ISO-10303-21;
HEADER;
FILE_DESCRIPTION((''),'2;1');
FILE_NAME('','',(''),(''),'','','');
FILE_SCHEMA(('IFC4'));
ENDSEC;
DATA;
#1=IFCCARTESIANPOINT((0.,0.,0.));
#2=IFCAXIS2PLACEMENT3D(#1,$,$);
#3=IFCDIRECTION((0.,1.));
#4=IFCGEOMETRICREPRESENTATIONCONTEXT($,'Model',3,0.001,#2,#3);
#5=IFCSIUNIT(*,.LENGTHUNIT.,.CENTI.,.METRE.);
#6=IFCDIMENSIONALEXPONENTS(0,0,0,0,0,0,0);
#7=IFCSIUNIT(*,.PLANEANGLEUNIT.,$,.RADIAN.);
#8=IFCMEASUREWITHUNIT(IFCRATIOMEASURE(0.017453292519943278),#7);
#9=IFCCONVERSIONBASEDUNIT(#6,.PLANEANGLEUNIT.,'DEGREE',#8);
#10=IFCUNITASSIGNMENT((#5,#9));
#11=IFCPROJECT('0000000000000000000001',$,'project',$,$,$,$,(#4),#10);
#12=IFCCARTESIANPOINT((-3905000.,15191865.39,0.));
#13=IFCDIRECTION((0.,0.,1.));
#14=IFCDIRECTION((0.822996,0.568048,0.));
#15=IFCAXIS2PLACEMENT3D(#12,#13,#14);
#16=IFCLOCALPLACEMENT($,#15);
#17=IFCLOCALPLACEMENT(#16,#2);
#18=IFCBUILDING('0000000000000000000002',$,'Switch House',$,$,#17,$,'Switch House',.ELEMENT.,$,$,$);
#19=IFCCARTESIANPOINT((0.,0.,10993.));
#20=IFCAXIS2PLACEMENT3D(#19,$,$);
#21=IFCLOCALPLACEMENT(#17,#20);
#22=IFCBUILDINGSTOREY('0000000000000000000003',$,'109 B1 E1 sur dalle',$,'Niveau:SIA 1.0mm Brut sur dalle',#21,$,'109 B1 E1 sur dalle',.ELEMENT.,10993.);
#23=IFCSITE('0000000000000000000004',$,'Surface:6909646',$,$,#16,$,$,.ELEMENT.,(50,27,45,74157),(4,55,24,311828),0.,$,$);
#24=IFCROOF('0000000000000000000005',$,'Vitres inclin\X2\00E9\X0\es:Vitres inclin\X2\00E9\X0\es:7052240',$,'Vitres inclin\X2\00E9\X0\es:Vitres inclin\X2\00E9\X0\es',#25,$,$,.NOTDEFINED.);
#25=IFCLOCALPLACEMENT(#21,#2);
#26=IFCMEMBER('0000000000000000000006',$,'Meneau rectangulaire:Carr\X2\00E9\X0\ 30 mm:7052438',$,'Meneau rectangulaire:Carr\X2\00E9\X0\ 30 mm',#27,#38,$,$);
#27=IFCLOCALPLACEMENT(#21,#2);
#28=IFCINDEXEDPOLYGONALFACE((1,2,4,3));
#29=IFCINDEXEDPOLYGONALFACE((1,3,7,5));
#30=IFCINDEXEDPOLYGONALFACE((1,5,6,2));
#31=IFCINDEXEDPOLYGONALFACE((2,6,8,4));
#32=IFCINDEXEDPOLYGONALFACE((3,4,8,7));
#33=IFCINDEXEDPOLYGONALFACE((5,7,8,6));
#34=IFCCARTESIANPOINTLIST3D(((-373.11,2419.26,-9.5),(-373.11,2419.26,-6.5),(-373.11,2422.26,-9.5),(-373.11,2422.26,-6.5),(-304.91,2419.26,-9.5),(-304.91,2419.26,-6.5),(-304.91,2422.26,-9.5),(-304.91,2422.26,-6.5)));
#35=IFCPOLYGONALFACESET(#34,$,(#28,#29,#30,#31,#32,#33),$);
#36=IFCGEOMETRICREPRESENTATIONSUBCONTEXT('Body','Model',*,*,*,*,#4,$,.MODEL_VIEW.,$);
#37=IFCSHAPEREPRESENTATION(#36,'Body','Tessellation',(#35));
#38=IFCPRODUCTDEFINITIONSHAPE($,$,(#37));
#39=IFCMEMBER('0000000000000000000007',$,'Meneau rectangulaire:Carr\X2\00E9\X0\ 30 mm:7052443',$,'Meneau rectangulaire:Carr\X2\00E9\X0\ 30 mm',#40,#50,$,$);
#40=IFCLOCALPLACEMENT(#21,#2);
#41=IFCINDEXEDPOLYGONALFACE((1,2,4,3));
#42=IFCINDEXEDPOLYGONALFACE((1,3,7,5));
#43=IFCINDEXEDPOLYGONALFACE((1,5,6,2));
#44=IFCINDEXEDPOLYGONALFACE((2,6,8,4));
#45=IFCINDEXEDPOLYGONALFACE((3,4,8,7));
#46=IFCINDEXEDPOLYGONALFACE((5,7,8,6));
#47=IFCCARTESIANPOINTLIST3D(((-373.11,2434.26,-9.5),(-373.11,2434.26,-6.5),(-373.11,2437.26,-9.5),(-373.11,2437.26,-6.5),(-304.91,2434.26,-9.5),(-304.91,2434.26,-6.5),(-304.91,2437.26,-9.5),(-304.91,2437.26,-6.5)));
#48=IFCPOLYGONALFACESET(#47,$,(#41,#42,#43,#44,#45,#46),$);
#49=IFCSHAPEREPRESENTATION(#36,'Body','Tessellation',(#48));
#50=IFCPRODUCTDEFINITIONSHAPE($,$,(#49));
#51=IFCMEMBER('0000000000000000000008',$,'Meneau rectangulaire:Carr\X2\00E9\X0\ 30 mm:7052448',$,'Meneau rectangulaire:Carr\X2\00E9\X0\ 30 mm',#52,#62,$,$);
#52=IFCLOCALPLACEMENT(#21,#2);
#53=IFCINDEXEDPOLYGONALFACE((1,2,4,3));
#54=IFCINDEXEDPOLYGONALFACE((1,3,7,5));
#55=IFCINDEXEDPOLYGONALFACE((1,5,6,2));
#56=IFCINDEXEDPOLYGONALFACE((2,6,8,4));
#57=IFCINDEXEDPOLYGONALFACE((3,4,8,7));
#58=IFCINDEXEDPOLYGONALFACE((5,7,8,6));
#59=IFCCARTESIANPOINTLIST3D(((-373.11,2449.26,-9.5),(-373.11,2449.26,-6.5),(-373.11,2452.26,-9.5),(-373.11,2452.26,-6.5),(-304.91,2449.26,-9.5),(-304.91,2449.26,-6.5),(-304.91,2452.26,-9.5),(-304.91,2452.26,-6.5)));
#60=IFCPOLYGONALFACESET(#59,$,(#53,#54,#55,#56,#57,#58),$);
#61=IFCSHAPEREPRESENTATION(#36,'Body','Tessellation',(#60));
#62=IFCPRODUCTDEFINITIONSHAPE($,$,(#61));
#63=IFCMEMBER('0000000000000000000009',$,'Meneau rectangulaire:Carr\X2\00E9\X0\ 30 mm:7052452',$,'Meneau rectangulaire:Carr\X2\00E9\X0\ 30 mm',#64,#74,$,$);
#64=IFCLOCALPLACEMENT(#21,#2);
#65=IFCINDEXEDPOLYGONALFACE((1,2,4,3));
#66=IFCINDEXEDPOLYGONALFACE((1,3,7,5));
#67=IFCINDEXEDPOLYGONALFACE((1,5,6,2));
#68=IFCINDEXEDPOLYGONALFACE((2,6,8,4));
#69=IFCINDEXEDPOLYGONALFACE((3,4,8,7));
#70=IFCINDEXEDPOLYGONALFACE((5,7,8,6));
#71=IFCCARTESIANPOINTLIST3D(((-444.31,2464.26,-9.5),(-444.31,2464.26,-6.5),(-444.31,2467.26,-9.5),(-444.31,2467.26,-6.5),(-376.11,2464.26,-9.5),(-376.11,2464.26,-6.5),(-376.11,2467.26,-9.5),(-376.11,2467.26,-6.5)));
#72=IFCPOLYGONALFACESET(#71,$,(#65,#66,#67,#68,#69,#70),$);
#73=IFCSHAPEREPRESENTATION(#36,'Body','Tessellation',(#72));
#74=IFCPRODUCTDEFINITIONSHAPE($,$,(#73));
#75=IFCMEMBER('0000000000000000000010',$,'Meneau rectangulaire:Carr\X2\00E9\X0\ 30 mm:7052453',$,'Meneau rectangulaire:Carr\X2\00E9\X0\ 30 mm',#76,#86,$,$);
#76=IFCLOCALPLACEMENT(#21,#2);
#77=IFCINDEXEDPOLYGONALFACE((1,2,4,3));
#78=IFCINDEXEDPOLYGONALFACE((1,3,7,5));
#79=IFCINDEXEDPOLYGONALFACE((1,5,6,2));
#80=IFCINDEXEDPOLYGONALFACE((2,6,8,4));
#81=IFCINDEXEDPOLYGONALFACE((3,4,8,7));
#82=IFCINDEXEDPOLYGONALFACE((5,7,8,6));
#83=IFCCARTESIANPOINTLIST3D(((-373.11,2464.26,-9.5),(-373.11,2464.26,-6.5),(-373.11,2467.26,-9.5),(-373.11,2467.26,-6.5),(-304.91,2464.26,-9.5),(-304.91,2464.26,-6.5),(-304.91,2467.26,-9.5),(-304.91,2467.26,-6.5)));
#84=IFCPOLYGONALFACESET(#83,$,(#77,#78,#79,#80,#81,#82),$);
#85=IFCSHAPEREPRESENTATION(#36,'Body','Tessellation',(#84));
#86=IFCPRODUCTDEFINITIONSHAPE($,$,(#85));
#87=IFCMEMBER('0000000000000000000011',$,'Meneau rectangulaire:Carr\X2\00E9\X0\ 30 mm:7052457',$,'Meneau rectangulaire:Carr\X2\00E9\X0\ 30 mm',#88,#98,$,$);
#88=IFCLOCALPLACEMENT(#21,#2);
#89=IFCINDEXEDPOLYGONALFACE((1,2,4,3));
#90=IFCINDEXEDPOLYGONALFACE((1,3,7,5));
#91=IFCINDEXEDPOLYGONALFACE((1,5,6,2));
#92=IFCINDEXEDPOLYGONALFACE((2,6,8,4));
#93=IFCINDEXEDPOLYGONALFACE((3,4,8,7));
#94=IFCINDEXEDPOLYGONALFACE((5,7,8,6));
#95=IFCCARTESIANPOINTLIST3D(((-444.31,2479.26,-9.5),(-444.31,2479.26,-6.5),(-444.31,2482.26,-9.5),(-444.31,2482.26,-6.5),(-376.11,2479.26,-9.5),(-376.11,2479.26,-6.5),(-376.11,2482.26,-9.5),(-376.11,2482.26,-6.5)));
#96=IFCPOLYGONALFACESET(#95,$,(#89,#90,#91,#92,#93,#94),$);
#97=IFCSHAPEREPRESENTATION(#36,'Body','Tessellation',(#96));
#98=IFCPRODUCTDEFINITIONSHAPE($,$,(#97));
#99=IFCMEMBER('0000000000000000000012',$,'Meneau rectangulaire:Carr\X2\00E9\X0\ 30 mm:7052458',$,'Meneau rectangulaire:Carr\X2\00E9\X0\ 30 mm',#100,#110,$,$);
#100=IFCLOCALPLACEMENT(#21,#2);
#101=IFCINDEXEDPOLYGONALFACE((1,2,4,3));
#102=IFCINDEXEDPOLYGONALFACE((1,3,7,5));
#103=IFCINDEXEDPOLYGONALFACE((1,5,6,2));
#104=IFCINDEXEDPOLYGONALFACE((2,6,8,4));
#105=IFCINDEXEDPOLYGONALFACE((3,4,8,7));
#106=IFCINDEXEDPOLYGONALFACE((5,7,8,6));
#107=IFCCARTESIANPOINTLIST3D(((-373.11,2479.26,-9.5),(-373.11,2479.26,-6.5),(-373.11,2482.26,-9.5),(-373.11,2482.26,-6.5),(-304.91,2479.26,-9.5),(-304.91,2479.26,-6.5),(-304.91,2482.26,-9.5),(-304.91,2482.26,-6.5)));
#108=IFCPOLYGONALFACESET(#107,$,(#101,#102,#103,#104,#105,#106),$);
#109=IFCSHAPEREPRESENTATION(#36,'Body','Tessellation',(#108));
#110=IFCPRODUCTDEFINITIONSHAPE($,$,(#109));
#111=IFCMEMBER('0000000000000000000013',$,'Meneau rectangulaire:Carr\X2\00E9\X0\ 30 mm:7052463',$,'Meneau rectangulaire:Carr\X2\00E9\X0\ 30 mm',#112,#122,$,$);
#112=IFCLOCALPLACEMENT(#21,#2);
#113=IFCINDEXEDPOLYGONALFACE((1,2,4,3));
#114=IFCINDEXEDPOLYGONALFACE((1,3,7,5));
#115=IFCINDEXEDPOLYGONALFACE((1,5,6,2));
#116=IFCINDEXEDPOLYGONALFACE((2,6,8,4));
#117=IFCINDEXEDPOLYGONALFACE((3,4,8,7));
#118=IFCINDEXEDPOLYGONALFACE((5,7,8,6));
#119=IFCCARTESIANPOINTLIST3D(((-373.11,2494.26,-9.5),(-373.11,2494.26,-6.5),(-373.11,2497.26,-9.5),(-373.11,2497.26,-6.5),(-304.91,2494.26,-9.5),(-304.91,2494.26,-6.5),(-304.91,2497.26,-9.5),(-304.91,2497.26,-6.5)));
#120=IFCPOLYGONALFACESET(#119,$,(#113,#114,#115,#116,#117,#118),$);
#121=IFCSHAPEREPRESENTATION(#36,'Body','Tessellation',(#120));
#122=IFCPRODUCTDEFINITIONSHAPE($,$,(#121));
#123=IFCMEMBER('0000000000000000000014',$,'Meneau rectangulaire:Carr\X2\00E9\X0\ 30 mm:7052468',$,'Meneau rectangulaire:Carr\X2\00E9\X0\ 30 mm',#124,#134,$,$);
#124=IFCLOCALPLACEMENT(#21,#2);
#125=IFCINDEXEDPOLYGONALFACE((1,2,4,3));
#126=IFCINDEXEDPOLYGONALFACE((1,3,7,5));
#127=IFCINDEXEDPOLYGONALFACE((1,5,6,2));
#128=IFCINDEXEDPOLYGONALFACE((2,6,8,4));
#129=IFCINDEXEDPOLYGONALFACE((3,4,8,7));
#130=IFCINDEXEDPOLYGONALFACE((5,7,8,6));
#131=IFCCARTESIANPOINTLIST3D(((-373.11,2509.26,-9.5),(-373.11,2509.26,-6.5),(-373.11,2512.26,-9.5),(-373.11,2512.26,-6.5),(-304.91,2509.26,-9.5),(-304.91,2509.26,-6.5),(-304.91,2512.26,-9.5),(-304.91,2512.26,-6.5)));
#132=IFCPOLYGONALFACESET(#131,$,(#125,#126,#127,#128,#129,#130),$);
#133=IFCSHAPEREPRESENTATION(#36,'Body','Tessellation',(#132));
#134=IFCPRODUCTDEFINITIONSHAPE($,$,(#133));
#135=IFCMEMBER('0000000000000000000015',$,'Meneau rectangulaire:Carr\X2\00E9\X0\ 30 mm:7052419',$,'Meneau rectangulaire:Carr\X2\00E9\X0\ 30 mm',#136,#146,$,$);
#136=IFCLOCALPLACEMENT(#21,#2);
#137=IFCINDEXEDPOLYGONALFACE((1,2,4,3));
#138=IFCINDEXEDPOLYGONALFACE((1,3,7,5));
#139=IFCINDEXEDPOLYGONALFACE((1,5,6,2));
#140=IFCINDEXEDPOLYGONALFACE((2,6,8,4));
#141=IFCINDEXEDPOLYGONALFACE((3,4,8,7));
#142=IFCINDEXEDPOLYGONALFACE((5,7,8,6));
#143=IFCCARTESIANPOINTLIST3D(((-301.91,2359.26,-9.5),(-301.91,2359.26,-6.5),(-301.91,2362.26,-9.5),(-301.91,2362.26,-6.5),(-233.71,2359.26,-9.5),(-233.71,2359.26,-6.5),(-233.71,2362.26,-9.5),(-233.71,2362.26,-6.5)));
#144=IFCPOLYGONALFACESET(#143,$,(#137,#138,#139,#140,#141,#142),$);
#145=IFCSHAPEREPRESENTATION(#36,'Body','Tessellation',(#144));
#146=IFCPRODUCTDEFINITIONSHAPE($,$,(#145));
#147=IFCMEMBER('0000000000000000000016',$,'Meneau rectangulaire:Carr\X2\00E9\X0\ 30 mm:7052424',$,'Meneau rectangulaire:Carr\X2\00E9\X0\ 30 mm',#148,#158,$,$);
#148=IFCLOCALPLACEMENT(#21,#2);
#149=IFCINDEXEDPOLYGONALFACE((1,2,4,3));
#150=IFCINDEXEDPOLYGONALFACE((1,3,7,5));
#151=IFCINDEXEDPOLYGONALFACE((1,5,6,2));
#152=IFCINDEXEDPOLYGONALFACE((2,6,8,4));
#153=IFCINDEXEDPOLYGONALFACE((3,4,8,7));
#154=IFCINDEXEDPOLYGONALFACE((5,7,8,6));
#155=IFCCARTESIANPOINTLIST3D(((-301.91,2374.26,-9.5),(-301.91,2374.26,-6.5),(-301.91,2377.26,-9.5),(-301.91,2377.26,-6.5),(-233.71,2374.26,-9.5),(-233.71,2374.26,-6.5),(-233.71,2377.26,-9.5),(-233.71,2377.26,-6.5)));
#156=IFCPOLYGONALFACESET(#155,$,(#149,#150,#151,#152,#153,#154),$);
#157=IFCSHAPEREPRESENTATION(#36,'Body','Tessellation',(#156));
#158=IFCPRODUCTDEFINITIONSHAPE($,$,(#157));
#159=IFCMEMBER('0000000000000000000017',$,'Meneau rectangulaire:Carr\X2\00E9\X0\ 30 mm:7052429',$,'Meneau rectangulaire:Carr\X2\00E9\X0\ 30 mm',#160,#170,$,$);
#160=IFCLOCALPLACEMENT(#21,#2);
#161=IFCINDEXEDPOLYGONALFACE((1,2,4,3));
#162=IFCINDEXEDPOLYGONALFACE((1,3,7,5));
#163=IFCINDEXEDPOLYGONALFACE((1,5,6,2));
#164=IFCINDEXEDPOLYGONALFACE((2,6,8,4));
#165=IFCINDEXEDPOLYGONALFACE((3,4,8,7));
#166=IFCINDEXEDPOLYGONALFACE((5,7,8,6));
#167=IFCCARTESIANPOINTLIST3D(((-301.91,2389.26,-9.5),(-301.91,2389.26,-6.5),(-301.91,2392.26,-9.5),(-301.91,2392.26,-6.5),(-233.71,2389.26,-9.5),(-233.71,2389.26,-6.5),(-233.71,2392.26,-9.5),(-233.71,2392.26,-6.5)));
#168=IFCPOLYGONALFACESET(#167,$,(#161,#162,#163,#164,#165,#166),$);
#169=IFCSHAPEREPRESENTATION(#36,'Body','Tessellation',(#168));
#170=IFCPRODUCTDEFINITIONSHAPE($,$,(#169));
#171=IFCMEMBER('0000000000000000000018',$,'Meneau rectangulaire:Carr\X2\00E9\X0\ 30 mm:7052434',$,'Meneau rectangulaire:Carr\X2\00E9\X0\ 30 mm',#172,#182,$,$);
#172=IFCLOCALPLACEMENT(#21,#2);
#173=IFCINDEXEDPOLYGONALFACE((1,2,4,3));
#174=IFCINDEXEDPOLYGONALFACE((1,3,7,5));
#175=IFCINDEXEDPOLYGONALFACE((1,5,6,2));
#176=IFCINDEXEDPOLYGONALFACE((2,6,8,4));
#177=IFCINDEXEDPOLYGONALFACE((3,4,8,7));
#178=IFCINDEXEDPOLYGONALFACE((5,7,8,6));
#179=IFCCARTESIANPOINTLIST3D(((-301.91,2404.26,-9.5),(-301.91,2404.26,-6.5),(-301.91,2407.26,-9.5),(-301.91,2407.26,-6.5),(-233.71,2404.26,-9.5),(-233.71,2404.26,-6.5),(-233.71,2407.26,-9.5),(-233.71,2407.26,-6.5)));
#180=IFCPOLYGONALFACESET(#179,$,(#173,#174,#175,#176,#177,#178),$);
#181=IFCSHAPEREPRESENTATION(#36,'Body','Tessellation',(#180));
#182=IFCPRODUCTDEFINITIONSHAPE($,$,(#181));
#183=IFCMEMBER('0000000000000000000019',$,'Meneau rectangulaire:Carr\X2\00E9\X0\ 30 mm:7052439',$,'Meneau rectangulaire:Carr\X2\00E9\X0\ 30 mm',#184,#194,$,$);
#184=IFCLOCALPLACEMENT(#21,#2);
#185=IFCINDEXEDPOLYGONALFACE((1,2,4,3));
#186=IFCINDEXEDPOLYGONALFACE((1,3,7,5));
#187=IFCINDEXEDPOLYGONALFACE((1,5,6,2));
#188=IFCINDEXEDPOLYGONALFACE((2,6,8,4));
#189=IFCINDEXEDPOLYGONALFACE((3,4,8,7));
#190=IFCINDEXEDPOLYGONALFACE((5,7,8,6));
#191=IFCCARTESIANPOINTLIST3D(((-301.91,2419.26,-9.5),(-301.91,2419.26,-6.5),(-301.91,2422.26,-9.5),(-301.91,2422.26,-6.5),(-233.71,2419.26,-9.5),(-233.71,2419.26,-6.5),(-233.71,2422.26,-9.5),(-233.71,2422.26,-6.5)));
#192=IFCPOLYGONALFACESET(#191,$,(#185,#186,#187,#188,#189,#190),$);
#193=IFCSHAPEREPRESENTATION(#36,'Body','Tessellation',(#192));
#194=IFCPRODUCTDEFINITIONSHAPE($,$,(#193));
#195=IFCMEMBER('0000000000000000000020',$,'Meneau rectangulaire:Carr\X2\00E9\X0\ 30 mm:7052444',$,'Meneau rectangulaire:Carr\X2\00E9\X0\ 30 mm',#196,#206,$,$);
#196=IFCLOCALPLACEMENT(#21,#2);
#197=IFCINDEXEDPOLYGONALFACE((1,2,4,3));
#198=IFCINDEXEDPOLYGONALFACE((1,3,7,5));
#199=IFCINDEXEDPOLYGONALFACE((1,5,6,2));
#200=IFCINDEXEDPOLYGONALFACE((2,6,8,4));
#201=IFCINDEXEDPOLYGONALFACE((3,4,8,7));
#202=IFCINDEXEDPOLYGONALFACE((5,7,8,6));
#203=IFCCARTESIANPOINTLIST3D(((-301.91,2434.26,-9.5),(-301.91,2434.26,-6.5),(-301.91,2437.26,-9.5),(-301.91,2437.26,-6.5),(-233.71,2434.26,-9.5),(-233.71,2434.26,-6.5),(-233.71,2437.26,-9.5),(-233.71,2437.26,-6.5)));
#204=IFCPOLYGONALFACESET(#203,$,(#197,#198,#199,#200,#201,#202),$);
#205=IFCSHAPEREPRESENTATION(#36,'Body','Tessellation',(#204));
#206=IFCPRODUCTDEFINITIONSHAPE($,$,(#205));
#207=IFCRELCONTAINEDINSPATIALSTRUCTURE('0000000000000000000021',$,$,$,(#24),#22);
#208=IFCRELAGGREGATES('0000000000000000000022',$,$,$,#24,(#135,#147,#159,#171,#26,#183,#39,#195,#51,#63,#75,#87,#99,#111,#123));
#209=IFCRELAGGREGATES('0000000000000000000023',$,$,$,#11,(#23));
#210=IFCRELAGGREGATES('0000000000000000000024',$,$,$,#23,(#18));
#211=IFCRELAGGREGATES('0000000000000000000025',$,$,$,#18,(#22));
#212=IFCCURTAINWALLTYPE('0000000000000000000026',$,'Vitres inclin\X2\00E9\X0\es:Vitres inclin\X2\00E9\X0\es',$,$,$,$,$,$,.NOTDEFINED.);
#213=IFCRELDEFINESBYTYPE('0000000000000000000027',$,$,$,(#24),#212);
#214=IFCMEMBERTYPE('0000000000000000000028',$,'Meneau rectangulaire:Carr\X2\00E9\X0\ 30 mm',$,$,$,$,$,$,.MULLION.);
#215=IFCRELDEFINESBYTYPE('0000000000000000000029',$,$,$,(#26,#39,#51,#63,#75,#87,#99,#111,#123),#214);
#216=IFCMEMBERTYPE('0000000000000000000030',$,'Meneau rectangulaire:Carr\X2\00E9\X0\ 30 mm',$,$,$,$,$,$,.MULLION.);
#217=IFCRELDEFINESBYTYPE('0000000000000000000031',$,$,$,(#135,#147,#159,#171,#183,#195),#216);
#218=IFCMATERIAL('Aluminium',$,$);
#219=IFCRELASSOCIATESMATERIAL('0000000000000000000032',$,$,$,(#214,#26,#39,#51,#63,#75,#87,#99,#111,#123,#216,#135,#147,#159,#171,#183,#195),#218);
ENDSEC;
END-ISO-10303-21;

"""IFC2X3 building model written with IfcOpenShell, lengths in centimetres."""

from ifc_helpers import new_model, entity, si_unit, converted_unit, direction, frame, origin, origin_2d_with_axis, place, context, subcontext, project, spatial, rectangle, extrude, source, transform, mapped, material, type_object, type_shapes, element, aggregate, save


model = new_model("IFC2X3")

# Units and contexts
model_context = context("Model", 3, precision=0.001, world=origin(), true_north=direction((0.0, 1.0)))
body_context = subcontext(model_context, "Body", "Model", "MODEL_VIEW")
ifc_project = project(units=[si_unit("LENGTHUNIT", "METRE", prefix="CENTI"), converted_unit("PLANEANGLEUNIT", "DEGREE", entity("IfcRatioMeasure", 0.017453292519943278), si_unit("PLANEANGLEUNIT", "RADIAN"), dimensions=[0, 0, 0, 0, 0, 0, 0])], contexts=[model_context])

# Site, building, storey
site_placement = place(None, frame((-3905000.0, 15191865.39, 0.0), z_axis=(0.0, 0.0, 1.0), x_axis=(0.822996, 0.568048, 0.0)))
site = spatial("IfcSite", under=ifc_project, at=site_placement, Name="Surface:6909646", CompositionType="ELEMENT", RefLatitude=(50, 27, 45, 74157), RefLongitude=(4, 55, 24, 311828), RefElevation=0.0)
building_placement = place(site_placement, origin())
building = spatial("IfcBuilding", under=site, at=building_placement, Name="Switch House", LongName="Switch House", CompositionType="ELEMENT")
storey_placement = place(building_placement, frame((0.0, 0.0, 10993.0)))
storey = spatial("IfcBuildingStorey", under=building, at=storey_placement, Name="109 B1 E1 sur dalle", ObjectType="Niveau:SIA 1.0mm Brut sur dalle", LongName="109 B1 E1 sur dalle", CompositionType="ELEMENT", Elevation=10993.0)

# Roof, members
curtain_wall_type = type_object("IfcCurtainWallType", Name="Vitres inclinées:Vitres inclinées", PredefinedType="NOTDEFINED")
roof_placement = place(storey_placement, frame((0.0, 0.0, -10993.0)))
roof = element("IfcRoof", 1, at=roof_placement, inside=storey, type_object=curtain_wall_type, Name="Vitres inclinées:Vitres inclinées:7052240", ObjectType="Vitres inclinées:Vitres inclinées", ShapeType="NOTDEFINED")
ifc_material = material(Name="Aluminium")
member_type_1 = type_object("IfcMemberType", Name="Meneau rectangulaire:Carré 30 mm", PredefinedType="MULLION", material=ifc_material)
shared_shape_1 = source(origin(), body_context, "Body", "SweptSolid", [
    extrude(rectangle(XDim=3.0, YDim=3.0, at=origin_2d_with_axis()), frame((0.0, 0.0, -68.2), z_axis=(0.0, 0.0, 1.0), x_axis=(0.0, -1.0, 0.0)), (0.0, 0.0, 1.0), 68.2),
])
type_shapes(member_type_1, [shared_shape_1])
member_1_placement = place(roof_placement, frame((-373.11, 2420.76, 10985.0), z_axis=(-1.0, 0.0, 0.0), x_axis=(0.0, 1.0, 0.0)))
member_1 = element("IfcMember", 2, at=member_1_placement, type_object=member_type_1, material=ifc_material, Name="Meneau rectangulaire:Carré 30 mm:7052438", ObjectType="Meneau rectangulaire:Carré 30 mm", context=body_context, shape_type="MappedRepresentation", body=[
    mapped(shared_shape_1, transform((0.0, 0.0, 0.0), scale=1.0)),
])
member_2_placement = place(roof_placement, frame((-373.11, 2435.76, 10985.0), z_axis=(-1.0, 0.0, 0.0), x_axis=(0.0, 1.0, 0.0)))
member_2 = element("IfcMember", 3, at=member_2_placement, type_object=member_type_1, material=ifc_material, Name="Meneau rectangulaire:Carré 30 mm:7052443", ObjectType="Meneau rectangulaire:Carré 30 mm", context=body_context, shape_type="MappedRepresentation", body=[
    mapped(shared_shape_1, transform((0.0, 0.0, 0.0), scale=1.0)),
])
member_3_placement = place(roof_placement, frame((-373.11, 2450.76, 10985.0), z_axis=(-1.0, 0.0, 0.0), x_axis=(0.0, 1.0, 0.0)))
member_3 = element("IfcMember", 4, at=member_3_placement, type_object=member_type_1, material=ifc_material, Name="Meneau rectangulaire:Carré 30 mm:7052448", ObjectType="Meneau rectangulaire:Carré 30 mm", context=body_context, shape_type="MappedRepresentation", body=[
    mapped(shared_shape_1, transform((0.0, 0.0, 0.0), scale=1.0)),
])
member_4_placement = place(roof_placement, frame((-444.31, 2465.76, 10985.0), z_axis=(-1.0, 0.0, 0.0), x_axis=(0.0, 1.0, 0.0)))
member_4 = element("IfcMember", 5, at=member_4_placement, type_object=member_type_1, material=ifc_material, Name="Meneau rectangulaire:Carré 30 mm:7052452", ObjectType="Meneau rectangulaire:Carré 30 mm", context=body_context, shape_type="MappedRepresentation", body=[
    mapped(shared_shape_1, transform((0.0, 0.0, 0.0), scale=1.0)),
])
member_5_placement = place(roof_placement, frame((-373.11, 2465.76, 10985.0), z_axis=(-1.0, 0.0, 0.0), x_axis=(0.0, 1.0, 0.0)))
member_5 = element("IfcMember", 6, at=member_5_placement, type_object=member_type_1, material=ifc_material, Name="Meneau rectangulaire:Carré 30 mm:7052453", ObjectType="Meneau rectangulaire:Carré 30 mm", context=body_context, shape_type="MappedRepresentation", body=[
    mapped(shared_shape_1, transform((0.0, 0.0, 0.0), scale=1.0)),
])
member_6_placement = place(roof_placement, frame((-444.31, 2480.76, 10985.0), z_axis=(-1.0, 0.0, 0.0), x_axis=(0.0, 1.0, 0.0)))
member_6 = element("IfcMember", 7, at=member_6_placement, type_object=member_type_1, material=ifc_material, Name="Meneau rectangulaire:Carré 30 mm:7052457", ObjectType="Meneau rectangulaire:Carré 30 mm", context=body_context, shape_type="MappedRepresentation", body=[
    mapped(shared_shape_1, transform((0.0, 0.0, 0.0), scale=1.0)),
])
member_7_placement = place(roof_placement, frame((-373.11, 2480.76, 10985.0), z_axis=(-1.0, 0.0, 0.0), x_axis=(0.0, 1.0, 0.0)))
member_7 = element("IfcMember", 8, at=member_7_placement, type_object=member_type_1, material=ifc_material, Name="Meneau rectangulaire:Carré 30 mm:7052458", ObjectType="Meneau rectangulaire:Carré 30 mm", context=body_context, shape_type="MappedRepresentation", body=[
    mapped(shared_shape_1, transform((0.0, 0.0, 0.0), scale=1.0)),
])
member_8_placement = place(roof_placement, frame((-373.11, 2495.76, 10985.0), z_axis=(-1.0, 0.0, 0.0), x_axis=(0.0, 1.0, 0.0)))
member_8 = element("IfcMember", 9, at=member_8_placement, type_object=member_type_1, material=ifc_material, Name="Meneau rectangulaire:Carré 30 mm:7052463", ObjectType="Meneau rectangulaire:Carré 30 mm", context=body_context, shape_type="MappedRepresentation", body=[
    mapped(shared_shape_1, transform((0.0, 0.0, 0.0), scale=1.0)),
])
member_9_placement = place(roof_placement, frame((-373.11, 2510.76, 10985.0), z_axis=(-1.0, 0.0, 0.0), x_axis=(0.0, 1.0, 0.0)))
member_9 = element("IfcMember", 10, at=member_9_placement, type_object=member_type_1, material=ifc_material, Name="Meneau rectangulaire:Carré 30 mm:7052468", ObjectType="Meneau rectangulaire:Carré 30 mm", context=body_context, shape_type="MappedRepresentation", body=[
    mapped(shared_shape_1, transform((0.0, 0.0, 0.0), scale=1.0)),
])
member_type_2 = type_object("IfcMemberType", Name="Meneau rectangulaire:Carré 30 mm", PredefinedType="MULLION", material=ifc_material)
shared_shape_2 = source(origin(), body_context, "Body", "SweptSolid", [
    extrude(rectangle(XDim=3.0, YDim=3.0, at=origin_2d_with_axis()), frame((0.0, 0.0, -68.2), z_axis=(0.0, 0.0, 1.0), x_axis=(0.0, -1.0, 0.0)), (0.0, 0.0, 1.0), 68.2),
])
type_shapes(member_type_2, [shared_shape_2])
member_10_placement = place(roof_placement, frame((-301.91, 2360.76, 10985.0), z_axis=(-1.0, 0.0, 0.0), x_axis=(0.0, 1.0, 0.0)))
member_10 = element("IfcMember", 11, at=member_10_placement, type_object=member_type_2, material=ifc_material, Name="Meneau rectangulaire:Carré 30 mm:7052419", ObjectType="Meneau rectangulaire:Carré 30 mm", context=body_context, shape_type="MappedRepresentation", body=[
    mapped(shared_shape_2, transform((0.0, 0.0, 0.0), scale=1.0)),
])
member_11_placement = place(roof_placement, frame((-301.91, 2375.76, 10985.0), z_axis=(-1.0, 0.0, 0.0), x_axis=(0.0, 1.0, 0.0)))
member_11 = element("IfcMember", 12, at=member_11_placement, type_object=member_type_2, material=ifc_material, Name="Meneau rectangulaire:Carré 30 mm:7052424", ObjectType="Meneau rectangulaire:Carré 30 mm", context=body_context, shape_type="MappedRepresentation", body=[
    mapped(shared_shape_2, transform((0.0, 0.0, 0.0), scale=1.0)),
])
member_12_placement = place(roof_placement, frame((-301.91, 2390.76, 10985.0), z_axis=(-1.0, 0.0, 0.0), x_axis=(0.0, 1.0, 0.0)))
member_12 = element("IfcMember", 13, at=member_12_placement, type_object=member_type_2, material=ifc_material, Name="Meneau rectangulaire:Carré 30 mm:7052429", ObjectType="Meneau rectangulaire:Carré 30 mm", context=body_context, shape_type="MappedRepresentation", body=[
    mapped(shared_shape_2, transform((0.0, 0.0, 0.0), scale=1.0)),
])
member_13_placement = place(roof_placement, frame((-301.91, 2405.76, 10985.0), z_axis=(-1.0, 0.0, 0.0), x_axis=(0.0, 1.0, 0.0)))
member_13 = element("IfcMember", 14, at=member_13_placement, type_object=member_type_2, material=ifc_material, Name="Meneau rectangulaire:Carré 30 mm:7052434", ObjectType="Meneau rectangulaire:Carré 30 mm", context=body_context, shape_type="MappedRepresentation", body=[
    mapped(shared_shape_2, transform((0.0, 0.0, 0.0), scale=1.0)),
])
member_14_placement = place(roof_placement, frame((-301.91, 2420.76, 10985.0), z_axis=(-1.0, 0.0, 0.0), x_axis=(0.0, 1.0, 0.0)))
member_14 = element("IfcMember", 15, at=member_14_placement, type_object=member_type_2, material=ifc_material, Name="Meneau rectangulaire:Carré 30 mm:7052439", ObjectType="Meneau rectangulaire:Carré 30 mm", context=body_context, shape_type="MappedRepresentation", body=[
    mapped(shared_shape_2, transform((0.0, 0.0, 0.0), scale=1.0)),
])
member_15_placement = place(roof_placement, frame((-301.91, 2435.76, 10985.0), z_axis=(-1.0, 0.0, 0.0), x_axis=(0.0, 1.0, 0.0)))
member_15 = element("IfcMember", 16, at=member_15_placement, type_object=member_type_2, material=ifc_material, Name="Meneau rectangulaire:Carré 30 mm:7052444", ObjectType="Meneau rectangulaire:Carré 30 mm", context=body_context, shape_type="MappedRepresentation", body=[
    mapped(shared_shape_2, transform((0.0, 0.0, 0.0), scale=1.0)),
])
aggregate(roof, [member_10, member_11, member_12, member_13, member_1, member_14, member_2, member_15, member_3, member_4, member_5, member_6, member_7, member_8, member_9])

save(model, "model.ifc")
